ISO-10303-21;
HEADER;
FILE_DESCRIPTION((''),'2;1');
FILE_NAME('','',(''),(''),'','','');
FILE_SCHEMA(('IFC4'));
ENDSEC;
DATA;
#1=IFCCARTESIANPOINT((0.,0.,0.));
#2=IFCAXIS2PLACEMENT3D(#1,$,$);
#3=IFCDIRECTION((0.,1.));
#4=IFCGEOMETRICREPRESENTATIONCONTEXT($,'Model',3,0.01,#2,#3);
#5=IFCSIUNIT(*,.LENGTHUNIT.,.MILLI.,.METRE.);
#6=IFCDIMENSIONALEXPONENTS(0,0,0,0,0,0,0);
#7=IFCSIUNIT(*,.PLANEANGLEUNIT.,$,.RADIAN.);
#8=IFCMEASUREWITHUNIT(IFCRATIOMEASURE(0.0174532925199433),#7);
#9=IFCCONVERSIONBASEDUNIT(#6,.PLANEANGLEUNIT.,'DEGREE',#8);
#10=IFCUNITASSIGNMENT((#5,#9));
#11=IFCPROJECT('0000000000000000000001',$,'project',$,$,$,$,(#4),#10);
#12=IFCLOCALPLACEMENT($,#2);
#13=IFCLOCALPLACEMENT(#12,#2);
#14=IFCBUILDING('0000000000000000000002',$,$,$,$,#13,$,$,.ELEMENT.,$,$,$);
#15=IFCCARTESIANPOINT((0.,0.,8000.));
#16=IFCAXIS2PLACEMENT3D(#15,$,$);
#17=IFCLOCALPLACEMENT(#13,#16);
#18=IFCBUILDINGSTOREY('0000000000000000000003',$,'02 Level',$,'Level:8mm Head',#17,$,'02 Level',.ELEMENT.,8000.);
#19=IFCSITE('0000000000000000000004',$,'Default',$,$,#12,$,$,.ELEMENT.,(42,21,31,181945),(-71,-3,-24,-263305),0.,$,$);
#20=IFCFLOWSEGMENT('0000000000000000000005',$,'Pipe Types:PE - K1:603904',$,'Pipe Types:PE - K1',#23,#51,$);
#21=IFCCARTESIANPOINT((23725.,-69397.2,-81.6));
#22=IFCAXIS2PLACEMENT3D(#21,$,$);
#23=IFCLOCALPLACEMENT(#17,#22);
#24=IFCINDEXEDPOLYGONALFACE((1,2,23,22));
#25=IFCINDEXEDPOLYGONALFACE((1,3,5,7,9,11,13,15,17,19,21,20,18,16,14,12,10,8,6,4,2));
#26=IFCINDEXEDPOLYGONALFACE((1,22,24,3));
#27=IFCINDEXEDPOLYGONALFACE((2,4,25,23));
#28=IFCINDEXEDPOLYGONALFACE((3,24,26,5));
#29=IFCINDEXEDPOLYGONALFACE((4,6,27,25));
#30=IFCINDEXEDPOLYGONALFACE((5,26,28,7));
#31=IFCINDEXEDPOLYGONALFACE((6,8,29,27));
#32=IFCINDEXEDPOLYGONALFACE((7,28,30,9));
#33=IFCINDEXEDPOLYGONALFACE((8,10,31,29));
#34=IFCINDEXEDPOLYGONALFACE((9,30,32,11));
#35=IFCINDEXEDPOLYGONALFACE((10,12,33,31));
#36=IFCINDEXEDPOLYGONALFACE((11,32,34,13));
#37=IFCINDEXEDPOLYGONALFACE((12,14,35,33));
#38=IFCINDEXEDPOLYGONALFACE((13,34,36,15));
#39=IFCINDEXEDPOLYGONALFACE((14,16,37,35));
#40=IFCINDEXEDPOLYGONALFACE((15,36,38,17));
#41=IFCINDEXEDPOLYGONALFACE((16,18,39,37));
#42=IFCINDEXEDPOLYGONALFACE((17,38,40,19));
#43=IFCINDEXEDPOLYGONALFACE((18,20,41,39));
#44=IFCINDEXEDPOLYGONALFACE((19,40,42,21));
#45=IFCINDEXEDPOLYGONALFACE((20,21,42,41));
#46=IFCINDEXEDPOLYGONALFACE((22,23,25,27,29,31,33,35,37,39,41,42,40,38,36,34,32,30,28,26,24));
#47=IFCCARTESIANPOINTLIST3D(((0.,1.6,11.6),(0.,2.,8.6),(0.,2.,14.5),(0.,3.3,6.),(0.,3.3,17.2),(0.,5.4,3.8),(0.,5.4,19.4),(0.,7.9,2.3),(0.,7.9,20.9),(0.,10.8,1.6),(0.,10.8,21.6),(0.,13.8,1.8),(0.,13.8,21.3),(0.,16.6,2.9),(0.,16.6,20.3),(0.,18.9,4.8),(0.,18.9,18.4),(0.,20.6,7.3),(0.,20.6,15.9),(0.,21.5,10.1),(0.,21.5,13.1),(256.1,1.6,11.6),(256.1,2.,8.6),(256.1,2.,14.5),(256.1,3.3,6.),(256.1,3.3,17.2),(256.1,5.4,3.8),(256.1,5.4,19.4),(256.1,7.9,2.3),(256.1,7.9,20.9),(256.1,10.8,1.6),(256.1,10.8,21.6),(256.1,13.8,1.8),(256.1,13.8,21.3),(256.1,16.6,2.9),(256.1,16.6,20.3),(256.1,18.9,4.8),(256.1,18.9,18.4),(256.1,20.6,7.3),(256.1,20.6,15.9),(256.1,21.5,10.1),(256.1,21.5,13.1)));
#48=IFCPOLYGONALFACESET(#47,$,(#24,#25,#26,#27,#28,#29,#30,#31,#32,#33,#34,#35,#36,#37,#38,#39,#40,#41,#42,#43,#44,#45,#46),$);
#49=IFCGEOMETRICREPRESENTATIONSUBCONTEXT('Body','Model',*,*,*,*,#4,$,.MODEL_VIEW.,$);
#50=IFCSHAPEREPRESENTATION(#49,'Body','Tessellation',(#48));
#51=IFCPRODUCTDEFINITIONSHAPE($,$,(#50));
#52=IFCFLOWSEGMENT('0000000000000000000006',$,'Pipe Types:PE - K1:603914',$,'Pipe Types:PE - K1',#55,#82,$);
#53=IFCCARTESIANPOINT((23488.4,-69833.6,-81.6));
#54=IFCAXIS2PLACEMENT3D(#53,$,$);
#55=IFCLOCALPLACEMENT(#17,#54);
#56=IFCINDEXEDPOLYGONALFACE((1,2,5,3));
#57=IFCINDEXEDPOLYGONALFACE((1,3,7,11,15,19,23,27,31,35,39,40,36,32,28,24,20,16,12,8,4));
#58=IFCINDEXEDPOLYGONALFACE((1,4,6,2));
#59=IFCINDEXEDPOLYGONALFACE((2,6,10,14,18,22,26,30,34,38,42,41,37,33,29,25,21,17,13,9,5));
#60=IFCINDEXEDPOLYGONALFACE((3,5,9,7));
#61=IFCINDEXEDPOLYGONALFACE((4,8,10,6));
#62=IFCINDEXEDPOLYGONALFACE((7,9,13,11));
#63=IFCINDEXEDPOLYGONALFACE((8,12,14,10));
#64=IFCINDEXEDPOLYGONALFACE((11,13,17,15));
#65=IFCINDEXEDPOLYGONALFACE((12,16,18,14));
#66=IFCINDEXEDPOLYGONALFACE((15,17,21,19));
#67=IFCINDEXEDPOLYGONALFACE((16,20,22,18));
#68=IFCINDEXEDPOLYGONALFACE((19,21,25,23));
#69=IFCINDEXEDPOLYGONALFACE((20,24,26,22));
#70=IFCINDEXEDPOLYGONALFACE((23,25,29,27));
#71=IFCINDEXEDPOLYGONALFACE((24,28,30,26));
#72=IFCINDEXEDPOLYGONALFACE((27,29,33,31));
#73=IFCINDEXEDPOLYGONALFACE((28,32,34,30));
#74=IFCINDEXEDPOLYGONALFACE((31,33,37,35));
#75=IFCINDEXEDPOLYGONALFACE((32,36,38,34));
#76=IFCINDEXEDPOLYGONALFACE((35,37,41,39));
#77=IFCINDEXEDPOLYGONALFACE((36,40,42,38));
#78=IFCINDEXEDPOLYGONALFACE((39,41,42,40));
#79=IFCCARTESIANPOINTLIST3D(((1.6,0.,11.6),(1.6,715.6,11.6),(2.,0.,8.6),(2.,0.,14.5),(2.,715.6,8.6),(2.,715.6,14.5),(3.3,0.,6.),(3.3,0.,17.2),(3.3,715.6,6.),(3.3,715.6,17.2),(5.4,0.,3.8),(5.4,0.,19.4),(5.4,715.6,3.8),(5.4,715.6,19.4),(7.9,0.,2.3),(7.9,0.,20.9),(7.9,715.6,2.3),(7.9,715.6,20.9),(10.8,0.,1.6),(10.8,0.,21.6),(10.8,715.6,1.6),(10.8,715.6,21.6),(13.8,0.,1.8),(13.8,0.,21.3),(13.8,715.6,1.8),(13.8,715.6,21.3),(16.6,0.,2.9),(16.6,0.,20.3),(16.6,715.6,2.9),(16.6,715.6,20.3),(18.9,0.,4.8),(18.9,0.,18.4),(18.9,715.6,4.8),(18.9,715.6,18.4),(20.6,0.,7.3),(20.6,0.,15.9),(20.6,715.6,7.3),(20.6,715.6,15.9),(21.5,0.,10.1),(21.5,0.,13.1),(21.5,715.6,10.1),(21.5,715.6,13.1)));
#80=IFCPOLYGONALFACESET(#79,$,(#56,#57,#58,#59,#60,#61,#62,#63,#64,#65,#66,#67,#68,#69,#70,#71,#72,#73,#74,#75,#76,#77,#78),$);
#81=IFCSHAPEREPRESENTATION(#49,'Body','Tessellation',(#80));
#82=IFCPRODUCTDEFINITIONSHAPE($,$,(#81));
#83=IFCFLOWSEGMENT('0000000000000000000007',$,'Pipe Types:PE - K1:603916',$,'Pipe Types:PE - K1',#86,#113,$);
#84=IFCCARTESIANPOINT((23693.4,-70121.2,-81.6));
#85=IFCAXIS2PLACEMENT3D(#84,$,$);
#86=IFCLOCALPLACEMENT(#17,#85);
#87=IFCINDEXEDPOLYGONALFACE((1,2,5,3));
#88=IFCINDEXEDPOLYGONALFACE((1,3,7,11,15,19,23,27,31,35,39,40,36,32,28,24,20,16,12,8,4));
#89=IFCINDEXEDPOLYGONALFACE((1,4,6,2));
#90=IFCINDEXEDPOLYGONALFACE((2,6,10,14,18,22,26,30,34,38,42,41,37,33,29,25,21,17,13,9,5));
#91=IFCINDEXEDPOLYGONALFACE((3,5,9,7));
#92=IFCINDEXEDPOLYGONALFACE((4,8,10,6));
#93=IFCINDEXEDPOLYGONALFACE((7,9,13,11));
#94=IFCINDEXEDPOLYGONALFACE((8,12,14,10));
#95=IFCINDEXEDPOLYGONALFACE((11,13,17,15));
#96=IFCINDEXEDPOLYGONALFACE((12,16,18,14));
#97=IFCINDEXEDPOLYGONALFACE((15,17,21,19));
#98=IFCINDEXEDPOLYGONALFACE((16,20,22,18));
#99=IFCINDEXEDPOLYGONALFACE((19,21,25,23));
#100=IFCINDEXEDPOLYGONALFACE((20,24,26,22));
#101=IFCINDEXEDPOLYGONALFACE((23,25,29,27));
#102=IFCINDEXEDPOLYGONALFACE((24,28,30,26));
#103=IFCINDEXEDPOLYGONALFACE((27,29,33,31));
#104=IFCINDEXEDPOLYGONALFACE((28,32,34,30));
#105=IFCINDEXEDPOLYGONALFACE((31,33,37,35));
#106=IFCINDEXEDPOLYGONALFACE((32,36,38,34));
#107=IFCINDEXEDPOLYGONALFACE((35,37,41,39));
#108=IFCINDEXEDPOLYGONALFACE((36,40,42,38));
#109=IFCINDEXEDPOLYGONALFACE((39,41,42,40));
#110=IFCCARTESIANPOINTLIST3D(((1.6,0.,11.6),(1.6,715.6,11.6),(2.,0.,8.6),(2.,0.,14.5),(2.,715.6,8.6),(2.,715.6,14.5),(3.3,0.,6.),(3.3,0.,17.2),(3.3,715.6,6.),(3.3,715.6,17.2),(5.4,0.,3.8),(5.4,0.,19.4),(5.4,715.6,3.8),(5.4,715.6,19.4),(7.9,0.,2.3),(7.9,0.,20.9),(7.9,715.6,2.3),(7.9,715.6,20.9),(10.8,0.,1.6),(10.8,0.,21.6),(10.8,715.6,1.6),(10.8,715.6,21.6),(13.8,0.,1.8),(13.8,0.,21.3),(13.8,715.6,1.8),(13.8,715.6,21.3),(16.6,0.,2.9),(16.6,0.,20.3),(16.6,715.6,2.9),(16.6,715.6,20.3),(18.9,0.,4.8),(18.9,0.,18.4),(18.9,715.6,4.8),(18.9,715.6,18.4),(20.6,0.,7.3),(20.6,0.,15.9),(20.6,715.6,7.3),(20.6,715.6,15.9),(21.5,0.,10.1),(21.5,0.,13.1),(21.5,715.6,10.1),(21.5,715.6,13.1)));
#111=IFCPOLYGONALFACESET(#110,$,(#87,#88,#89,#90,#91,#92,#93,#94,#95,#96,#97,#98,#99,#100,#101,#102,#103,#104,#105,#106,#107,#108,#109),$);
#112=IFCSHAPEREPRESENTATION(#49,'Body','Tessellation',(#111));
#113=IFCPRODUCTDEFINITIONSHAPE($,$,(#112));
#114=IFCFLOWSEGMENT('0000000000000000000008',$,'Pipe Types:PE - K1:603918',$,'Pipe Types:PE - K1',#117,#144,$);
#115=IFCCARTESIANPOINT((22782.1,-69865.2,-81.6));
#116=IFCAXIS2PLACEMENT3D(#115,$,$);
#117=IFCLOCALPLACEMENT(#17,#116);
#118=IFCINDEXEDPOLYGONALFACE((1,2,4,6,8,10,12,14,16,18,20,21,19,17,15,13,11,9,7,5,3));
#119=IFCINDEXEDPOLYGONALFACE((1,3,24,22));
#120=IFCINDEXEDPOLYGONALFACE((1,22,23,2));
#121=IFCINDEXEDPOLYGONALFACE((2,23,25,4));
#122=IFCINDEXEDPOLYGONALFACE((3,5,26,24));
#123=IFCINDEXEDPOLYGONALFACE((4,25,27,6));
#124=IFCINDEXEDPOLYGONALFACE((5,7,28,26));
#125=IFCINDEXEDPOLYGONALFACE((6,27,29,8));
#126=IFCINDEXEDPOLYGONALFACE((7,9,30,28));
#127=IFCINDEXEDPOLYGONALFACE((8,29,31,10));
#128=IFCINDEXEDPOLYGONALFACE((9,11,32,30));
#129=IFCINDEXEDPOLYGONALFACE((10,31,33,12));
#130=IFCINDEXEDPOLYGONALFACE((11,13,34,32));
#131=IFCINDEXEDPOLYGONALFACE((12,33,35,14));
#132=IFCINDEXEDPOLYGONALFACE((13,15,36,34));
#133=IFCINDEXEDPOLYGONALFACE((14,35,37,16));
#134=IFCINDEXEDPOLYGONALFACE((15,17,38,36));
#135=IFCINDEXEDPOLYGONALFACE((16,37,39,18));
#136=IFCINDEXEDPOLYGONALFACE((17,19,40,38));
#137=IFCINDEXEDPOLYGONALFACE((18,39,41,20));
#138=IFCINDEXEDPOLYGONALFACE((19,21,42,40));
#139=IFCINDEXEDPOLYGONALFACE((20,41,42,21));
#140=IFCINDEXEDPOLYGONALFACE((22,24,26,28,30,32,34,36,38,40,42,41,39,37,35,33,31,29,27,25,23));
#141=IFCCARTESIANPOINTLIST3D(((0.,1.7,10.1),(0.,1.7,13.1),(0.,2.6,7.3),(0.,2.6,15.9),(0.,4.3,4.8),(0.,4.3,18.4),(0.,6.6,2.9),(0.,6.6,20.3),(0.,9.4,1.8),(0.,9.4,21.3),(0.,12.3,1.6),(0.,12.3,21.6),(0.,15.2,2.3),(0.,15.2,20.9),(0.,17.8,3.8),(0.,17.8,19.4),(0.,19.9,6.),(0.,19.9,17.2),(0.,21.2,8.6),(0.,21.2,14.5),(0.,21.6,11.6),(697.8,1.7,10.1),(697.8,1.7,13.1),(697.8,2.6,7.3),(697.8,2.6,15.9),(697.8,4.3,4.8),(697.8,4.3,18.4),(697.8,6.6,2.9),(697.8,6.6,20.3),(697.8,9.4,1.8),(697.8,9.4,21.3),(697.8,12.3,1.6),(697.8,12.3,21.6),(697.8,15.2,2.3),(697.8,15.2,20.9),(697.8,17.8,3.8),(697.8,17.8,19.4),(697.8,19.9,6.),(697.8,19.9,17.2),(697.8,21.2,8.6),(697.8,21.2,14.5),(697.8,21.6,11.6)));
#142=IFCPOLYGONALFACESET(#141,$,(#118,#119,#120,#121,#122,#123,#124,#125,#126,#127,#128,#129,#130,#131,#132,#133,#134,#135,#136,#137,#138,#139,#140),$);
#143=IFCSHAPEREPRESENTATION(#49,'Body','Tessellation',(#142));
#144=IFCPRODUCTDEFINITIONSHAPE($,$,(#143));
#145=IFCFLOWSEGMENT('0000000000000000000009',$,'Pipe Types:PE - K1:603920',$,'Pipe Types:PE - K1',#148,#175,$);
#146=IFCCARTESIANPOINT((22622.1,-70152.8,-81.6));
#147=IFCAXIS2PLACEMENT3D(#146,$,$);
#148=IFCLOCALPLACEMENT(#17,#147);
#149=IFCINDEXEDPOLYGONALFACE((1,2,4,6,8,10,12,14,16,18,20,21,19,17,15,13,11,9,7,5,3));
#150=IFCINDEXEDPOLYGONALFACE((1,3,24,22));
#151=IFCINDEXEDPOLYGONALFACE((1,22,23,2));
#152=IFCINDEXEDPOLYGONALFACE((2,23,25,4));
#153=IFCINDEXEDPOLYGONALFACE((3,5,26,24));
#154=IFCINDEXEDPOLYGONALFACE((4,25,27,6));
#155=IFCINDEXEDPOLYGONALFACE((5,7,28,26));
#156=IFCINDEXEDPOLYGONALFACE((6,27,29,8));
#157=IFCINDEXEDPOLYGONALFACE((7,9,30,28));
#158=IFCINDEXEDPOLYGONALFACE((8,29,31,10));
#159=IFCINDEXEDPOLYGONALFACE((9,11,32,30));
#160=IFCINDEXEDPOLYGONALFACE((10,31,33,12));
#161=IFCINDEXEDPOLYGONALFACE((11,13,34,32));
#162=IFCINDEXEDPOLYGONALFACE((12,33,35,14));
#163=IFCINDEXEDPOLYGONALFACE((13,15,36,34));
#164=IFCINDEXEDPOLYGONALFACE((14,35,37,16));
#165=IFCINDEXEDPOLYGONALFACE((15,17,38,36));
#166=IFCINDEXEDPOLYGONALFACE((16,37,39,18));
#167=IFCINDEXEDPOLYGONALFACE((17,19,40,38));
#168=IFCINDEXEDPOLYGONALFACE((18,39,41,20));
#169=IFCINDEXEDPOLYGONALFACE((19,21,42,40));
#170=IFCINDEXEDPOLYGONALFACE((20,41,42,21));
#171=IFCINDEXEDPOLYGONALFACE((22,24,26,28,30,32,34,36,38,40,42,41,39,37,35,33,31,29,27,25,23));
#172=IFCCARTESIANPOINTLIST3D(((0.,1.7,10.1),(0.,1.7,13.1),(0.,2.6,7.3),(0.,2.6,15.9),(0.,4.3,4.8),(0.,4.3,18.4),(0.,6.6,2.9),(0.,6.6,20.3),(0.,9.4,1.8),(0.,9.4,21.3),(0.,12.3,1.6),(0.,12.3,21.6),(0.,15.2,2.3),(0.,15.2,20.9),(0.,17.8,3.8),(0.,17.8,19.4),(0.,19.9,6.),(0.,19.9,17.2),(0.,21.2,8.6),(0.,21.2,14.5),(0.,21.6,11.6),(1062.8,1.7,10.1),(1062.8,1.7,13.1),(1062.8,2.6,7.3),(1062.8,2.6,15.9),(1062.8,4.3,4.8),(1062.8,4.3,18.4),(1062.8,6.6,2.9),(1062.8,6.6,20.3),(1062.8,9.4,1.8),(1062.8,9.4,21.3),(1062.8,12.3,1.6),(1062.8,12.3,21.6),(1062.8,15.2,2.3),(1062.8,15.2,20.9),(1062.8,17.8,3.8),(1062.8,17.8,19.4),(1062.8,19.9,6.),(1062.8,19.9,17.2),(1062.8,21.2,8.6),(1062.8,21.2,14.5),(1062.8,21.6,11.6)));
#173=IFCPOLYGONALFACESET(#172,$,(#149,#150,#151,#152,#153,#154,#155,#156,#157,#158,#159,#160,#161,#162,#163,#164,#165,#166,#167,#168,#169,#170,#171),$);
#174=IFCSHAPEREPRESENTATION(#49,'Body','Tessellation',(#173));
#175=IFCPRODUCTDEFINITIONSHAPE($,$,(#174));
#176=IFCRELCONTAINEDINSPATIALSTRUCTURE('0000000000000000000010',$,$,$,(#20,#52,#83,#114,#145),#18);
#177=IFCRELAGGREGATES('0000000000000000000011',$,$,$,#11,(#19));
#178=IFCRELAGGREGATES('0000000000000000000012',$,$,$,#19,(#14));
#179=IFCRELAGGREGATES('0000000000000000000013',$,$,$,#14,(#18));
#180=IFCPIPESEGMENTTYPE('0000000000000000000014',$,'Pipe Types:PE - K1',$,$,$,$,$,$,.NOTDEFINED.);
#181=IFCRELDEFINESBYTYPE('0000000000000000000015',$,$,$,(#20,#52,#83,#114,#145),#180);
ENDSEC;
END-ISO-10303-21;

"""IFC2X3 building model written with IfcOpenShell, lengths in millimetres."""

from ifc_helpers import new_model, entity, si_unit, converted_unit, direction, frame, frame_2d, origin, origin_2d_with_axis, place, context, subcontext, project, spatial, circle, extrude, type_object, element, save


model = new_model("IFC2X3")

# Units and contexts
model_context = context("Model", 3, precision=0.01, world=origin(), true_north=direction((0.0, 1.0)))
body_context = subcontext(model_context, "Body", "Model", "MODEL_VIEW")
ifc_project = project(units=[si_unit("LENGTHUNIT", "METRE", prefix="MILLI"), converted_unit("PLANEANGLEUNIT", "DEGREE", entity("IfcRatioMeasure", 0.0174532925199433), si_unit("PLANEANGLEUNIT", "RADIAN"), dimensions=[0, 0, 0, 0, 0, 0, 0])], contexts=[model_context])

# Site, building, storey
site_placement = place(None, origin())
site = spatial("IfcSite", under=ifc_project, at=site_placement, Name="Default", CompositionType="ELEMENT", RefLatitude=(42, 21, 31, 181945), RefLongitude=(-71, -3, -24, -263305), RefElevation=0.0)
building_placement = place(site_placement, origin())
building = spatial("IfcBuilding", under=site, at=building_placement, CompositionType="ELEMENT")
storey_placement = place(building_placement, frame((0.0, 0.0, 8000.0)))
storey = spatial("IfcBuildingStorey", under=building, at=storey_placement, Name="02 Level", ObjectType="Level:8mm Head", LongName="02 Level", CompositionType="ELEMENT", Elevation=8000.0)

# Flow segments
pipe_segment_type = type_object("IfcPipeSegmentType", Name="Pipe Types:PE - K1", PredefinedType="NOTDEFINED")
flow_segment_1_placement = place(storey_placement, frame((23725.0, -69397.2, -81.6)))
element("IfcFlowSegment", 1, at=flow_segment_1_placement, inside=storey, type_object=pipe_segment_type, Name="Pipe Types:PE - K1:603904", ObjectType="Pipe Types:PE - K1", context=body_context, shape_type="SweptSolid", body=[
    extrude(circle(Radius=10.0, at=origin_2d_with_axis()), frame((0.0, 11.6, 11.6), z_axis=(1.0, 0.0, 0.0), x_axis=(0.0, -1.0, 0.0)), (0.0, 0.0, 1.0), 256.1),
])
for number, where, name in (
    (2, (23488.4, -69833.6, -81.6), "Pipe Types:PE - K1:603914"),
    (3, (23693.4, -70121.2, -81.6), "Pipe Types:PE - K1:603916"),
):
    element("IfcFlowSegment", number, at=place(storey_placement, frame(where)), inside=storey, type_object=pipe_segment_type, Name=name, ObjectType="Pipe Types:PE - K1", context=body_context, shape_type="SweptSolid", body=[
        extrude(circle(Radius=10.0, at=frame_2d((0.0, 0.0), x_axis=(1.0, 0.0))), frame((11.6, 0.0, 11.6), z_axis=(0.0, 1.0, 0.0), x_axis=(-1.0, 0.0, 0.0)), (0.0, 0.0, 1.0), 715.6),
    ])
flow_segment_2_placement = place(storey_placement, frame((22782.1, -69865.2, -81.6)))
element("IfcFlowSegment", 4, at=flow_segment_2_placement, inside=storey, type_object=pipe_segment_type, Name="Pipe Types:PE - K1:603918", ObjectType="Pipe Types:PE - K1", context=body_context, shape_type="SweptSolid", body=[
    extrude(circle(Radius=10.0, at=frame_2d((0.0, 0.0), x_axis=(1.0, 0.0))), frame((0.0, 11.6, 11.6), z_axis=(1.0, 0.0, 0.0), x_axis=(0.0, 1.0, 0.0)), (0.0, 0.0, 1.0), 697.8),
])
flow_segment_3_placement = place(storey_placement, frame((22622.1, -70152.8, -81.6)))
element("IfcFlowSegment", 5, at=flow_segment_3_placement, inside=storey, type_object=pipe_segment_type, Name="Pipe Types:PE - K1:603920", ObjectType="Pipe Types:PE - K1", context=body_context, shape_type="SweptSolid", body=[
    extrude(circle(Radius=10.0, at=frame_2d((0.0, 0.0), x_axis=(1.0, 0.0))), frame((0.0, 11.6, 11.6), z_axis=(1.0, 0.0, 0.0), x_axis=(0.0, 1.0, 0.0)), (0.0, 0.0, 1.0), 1062.8),
])

save(model, "model.ifc")
